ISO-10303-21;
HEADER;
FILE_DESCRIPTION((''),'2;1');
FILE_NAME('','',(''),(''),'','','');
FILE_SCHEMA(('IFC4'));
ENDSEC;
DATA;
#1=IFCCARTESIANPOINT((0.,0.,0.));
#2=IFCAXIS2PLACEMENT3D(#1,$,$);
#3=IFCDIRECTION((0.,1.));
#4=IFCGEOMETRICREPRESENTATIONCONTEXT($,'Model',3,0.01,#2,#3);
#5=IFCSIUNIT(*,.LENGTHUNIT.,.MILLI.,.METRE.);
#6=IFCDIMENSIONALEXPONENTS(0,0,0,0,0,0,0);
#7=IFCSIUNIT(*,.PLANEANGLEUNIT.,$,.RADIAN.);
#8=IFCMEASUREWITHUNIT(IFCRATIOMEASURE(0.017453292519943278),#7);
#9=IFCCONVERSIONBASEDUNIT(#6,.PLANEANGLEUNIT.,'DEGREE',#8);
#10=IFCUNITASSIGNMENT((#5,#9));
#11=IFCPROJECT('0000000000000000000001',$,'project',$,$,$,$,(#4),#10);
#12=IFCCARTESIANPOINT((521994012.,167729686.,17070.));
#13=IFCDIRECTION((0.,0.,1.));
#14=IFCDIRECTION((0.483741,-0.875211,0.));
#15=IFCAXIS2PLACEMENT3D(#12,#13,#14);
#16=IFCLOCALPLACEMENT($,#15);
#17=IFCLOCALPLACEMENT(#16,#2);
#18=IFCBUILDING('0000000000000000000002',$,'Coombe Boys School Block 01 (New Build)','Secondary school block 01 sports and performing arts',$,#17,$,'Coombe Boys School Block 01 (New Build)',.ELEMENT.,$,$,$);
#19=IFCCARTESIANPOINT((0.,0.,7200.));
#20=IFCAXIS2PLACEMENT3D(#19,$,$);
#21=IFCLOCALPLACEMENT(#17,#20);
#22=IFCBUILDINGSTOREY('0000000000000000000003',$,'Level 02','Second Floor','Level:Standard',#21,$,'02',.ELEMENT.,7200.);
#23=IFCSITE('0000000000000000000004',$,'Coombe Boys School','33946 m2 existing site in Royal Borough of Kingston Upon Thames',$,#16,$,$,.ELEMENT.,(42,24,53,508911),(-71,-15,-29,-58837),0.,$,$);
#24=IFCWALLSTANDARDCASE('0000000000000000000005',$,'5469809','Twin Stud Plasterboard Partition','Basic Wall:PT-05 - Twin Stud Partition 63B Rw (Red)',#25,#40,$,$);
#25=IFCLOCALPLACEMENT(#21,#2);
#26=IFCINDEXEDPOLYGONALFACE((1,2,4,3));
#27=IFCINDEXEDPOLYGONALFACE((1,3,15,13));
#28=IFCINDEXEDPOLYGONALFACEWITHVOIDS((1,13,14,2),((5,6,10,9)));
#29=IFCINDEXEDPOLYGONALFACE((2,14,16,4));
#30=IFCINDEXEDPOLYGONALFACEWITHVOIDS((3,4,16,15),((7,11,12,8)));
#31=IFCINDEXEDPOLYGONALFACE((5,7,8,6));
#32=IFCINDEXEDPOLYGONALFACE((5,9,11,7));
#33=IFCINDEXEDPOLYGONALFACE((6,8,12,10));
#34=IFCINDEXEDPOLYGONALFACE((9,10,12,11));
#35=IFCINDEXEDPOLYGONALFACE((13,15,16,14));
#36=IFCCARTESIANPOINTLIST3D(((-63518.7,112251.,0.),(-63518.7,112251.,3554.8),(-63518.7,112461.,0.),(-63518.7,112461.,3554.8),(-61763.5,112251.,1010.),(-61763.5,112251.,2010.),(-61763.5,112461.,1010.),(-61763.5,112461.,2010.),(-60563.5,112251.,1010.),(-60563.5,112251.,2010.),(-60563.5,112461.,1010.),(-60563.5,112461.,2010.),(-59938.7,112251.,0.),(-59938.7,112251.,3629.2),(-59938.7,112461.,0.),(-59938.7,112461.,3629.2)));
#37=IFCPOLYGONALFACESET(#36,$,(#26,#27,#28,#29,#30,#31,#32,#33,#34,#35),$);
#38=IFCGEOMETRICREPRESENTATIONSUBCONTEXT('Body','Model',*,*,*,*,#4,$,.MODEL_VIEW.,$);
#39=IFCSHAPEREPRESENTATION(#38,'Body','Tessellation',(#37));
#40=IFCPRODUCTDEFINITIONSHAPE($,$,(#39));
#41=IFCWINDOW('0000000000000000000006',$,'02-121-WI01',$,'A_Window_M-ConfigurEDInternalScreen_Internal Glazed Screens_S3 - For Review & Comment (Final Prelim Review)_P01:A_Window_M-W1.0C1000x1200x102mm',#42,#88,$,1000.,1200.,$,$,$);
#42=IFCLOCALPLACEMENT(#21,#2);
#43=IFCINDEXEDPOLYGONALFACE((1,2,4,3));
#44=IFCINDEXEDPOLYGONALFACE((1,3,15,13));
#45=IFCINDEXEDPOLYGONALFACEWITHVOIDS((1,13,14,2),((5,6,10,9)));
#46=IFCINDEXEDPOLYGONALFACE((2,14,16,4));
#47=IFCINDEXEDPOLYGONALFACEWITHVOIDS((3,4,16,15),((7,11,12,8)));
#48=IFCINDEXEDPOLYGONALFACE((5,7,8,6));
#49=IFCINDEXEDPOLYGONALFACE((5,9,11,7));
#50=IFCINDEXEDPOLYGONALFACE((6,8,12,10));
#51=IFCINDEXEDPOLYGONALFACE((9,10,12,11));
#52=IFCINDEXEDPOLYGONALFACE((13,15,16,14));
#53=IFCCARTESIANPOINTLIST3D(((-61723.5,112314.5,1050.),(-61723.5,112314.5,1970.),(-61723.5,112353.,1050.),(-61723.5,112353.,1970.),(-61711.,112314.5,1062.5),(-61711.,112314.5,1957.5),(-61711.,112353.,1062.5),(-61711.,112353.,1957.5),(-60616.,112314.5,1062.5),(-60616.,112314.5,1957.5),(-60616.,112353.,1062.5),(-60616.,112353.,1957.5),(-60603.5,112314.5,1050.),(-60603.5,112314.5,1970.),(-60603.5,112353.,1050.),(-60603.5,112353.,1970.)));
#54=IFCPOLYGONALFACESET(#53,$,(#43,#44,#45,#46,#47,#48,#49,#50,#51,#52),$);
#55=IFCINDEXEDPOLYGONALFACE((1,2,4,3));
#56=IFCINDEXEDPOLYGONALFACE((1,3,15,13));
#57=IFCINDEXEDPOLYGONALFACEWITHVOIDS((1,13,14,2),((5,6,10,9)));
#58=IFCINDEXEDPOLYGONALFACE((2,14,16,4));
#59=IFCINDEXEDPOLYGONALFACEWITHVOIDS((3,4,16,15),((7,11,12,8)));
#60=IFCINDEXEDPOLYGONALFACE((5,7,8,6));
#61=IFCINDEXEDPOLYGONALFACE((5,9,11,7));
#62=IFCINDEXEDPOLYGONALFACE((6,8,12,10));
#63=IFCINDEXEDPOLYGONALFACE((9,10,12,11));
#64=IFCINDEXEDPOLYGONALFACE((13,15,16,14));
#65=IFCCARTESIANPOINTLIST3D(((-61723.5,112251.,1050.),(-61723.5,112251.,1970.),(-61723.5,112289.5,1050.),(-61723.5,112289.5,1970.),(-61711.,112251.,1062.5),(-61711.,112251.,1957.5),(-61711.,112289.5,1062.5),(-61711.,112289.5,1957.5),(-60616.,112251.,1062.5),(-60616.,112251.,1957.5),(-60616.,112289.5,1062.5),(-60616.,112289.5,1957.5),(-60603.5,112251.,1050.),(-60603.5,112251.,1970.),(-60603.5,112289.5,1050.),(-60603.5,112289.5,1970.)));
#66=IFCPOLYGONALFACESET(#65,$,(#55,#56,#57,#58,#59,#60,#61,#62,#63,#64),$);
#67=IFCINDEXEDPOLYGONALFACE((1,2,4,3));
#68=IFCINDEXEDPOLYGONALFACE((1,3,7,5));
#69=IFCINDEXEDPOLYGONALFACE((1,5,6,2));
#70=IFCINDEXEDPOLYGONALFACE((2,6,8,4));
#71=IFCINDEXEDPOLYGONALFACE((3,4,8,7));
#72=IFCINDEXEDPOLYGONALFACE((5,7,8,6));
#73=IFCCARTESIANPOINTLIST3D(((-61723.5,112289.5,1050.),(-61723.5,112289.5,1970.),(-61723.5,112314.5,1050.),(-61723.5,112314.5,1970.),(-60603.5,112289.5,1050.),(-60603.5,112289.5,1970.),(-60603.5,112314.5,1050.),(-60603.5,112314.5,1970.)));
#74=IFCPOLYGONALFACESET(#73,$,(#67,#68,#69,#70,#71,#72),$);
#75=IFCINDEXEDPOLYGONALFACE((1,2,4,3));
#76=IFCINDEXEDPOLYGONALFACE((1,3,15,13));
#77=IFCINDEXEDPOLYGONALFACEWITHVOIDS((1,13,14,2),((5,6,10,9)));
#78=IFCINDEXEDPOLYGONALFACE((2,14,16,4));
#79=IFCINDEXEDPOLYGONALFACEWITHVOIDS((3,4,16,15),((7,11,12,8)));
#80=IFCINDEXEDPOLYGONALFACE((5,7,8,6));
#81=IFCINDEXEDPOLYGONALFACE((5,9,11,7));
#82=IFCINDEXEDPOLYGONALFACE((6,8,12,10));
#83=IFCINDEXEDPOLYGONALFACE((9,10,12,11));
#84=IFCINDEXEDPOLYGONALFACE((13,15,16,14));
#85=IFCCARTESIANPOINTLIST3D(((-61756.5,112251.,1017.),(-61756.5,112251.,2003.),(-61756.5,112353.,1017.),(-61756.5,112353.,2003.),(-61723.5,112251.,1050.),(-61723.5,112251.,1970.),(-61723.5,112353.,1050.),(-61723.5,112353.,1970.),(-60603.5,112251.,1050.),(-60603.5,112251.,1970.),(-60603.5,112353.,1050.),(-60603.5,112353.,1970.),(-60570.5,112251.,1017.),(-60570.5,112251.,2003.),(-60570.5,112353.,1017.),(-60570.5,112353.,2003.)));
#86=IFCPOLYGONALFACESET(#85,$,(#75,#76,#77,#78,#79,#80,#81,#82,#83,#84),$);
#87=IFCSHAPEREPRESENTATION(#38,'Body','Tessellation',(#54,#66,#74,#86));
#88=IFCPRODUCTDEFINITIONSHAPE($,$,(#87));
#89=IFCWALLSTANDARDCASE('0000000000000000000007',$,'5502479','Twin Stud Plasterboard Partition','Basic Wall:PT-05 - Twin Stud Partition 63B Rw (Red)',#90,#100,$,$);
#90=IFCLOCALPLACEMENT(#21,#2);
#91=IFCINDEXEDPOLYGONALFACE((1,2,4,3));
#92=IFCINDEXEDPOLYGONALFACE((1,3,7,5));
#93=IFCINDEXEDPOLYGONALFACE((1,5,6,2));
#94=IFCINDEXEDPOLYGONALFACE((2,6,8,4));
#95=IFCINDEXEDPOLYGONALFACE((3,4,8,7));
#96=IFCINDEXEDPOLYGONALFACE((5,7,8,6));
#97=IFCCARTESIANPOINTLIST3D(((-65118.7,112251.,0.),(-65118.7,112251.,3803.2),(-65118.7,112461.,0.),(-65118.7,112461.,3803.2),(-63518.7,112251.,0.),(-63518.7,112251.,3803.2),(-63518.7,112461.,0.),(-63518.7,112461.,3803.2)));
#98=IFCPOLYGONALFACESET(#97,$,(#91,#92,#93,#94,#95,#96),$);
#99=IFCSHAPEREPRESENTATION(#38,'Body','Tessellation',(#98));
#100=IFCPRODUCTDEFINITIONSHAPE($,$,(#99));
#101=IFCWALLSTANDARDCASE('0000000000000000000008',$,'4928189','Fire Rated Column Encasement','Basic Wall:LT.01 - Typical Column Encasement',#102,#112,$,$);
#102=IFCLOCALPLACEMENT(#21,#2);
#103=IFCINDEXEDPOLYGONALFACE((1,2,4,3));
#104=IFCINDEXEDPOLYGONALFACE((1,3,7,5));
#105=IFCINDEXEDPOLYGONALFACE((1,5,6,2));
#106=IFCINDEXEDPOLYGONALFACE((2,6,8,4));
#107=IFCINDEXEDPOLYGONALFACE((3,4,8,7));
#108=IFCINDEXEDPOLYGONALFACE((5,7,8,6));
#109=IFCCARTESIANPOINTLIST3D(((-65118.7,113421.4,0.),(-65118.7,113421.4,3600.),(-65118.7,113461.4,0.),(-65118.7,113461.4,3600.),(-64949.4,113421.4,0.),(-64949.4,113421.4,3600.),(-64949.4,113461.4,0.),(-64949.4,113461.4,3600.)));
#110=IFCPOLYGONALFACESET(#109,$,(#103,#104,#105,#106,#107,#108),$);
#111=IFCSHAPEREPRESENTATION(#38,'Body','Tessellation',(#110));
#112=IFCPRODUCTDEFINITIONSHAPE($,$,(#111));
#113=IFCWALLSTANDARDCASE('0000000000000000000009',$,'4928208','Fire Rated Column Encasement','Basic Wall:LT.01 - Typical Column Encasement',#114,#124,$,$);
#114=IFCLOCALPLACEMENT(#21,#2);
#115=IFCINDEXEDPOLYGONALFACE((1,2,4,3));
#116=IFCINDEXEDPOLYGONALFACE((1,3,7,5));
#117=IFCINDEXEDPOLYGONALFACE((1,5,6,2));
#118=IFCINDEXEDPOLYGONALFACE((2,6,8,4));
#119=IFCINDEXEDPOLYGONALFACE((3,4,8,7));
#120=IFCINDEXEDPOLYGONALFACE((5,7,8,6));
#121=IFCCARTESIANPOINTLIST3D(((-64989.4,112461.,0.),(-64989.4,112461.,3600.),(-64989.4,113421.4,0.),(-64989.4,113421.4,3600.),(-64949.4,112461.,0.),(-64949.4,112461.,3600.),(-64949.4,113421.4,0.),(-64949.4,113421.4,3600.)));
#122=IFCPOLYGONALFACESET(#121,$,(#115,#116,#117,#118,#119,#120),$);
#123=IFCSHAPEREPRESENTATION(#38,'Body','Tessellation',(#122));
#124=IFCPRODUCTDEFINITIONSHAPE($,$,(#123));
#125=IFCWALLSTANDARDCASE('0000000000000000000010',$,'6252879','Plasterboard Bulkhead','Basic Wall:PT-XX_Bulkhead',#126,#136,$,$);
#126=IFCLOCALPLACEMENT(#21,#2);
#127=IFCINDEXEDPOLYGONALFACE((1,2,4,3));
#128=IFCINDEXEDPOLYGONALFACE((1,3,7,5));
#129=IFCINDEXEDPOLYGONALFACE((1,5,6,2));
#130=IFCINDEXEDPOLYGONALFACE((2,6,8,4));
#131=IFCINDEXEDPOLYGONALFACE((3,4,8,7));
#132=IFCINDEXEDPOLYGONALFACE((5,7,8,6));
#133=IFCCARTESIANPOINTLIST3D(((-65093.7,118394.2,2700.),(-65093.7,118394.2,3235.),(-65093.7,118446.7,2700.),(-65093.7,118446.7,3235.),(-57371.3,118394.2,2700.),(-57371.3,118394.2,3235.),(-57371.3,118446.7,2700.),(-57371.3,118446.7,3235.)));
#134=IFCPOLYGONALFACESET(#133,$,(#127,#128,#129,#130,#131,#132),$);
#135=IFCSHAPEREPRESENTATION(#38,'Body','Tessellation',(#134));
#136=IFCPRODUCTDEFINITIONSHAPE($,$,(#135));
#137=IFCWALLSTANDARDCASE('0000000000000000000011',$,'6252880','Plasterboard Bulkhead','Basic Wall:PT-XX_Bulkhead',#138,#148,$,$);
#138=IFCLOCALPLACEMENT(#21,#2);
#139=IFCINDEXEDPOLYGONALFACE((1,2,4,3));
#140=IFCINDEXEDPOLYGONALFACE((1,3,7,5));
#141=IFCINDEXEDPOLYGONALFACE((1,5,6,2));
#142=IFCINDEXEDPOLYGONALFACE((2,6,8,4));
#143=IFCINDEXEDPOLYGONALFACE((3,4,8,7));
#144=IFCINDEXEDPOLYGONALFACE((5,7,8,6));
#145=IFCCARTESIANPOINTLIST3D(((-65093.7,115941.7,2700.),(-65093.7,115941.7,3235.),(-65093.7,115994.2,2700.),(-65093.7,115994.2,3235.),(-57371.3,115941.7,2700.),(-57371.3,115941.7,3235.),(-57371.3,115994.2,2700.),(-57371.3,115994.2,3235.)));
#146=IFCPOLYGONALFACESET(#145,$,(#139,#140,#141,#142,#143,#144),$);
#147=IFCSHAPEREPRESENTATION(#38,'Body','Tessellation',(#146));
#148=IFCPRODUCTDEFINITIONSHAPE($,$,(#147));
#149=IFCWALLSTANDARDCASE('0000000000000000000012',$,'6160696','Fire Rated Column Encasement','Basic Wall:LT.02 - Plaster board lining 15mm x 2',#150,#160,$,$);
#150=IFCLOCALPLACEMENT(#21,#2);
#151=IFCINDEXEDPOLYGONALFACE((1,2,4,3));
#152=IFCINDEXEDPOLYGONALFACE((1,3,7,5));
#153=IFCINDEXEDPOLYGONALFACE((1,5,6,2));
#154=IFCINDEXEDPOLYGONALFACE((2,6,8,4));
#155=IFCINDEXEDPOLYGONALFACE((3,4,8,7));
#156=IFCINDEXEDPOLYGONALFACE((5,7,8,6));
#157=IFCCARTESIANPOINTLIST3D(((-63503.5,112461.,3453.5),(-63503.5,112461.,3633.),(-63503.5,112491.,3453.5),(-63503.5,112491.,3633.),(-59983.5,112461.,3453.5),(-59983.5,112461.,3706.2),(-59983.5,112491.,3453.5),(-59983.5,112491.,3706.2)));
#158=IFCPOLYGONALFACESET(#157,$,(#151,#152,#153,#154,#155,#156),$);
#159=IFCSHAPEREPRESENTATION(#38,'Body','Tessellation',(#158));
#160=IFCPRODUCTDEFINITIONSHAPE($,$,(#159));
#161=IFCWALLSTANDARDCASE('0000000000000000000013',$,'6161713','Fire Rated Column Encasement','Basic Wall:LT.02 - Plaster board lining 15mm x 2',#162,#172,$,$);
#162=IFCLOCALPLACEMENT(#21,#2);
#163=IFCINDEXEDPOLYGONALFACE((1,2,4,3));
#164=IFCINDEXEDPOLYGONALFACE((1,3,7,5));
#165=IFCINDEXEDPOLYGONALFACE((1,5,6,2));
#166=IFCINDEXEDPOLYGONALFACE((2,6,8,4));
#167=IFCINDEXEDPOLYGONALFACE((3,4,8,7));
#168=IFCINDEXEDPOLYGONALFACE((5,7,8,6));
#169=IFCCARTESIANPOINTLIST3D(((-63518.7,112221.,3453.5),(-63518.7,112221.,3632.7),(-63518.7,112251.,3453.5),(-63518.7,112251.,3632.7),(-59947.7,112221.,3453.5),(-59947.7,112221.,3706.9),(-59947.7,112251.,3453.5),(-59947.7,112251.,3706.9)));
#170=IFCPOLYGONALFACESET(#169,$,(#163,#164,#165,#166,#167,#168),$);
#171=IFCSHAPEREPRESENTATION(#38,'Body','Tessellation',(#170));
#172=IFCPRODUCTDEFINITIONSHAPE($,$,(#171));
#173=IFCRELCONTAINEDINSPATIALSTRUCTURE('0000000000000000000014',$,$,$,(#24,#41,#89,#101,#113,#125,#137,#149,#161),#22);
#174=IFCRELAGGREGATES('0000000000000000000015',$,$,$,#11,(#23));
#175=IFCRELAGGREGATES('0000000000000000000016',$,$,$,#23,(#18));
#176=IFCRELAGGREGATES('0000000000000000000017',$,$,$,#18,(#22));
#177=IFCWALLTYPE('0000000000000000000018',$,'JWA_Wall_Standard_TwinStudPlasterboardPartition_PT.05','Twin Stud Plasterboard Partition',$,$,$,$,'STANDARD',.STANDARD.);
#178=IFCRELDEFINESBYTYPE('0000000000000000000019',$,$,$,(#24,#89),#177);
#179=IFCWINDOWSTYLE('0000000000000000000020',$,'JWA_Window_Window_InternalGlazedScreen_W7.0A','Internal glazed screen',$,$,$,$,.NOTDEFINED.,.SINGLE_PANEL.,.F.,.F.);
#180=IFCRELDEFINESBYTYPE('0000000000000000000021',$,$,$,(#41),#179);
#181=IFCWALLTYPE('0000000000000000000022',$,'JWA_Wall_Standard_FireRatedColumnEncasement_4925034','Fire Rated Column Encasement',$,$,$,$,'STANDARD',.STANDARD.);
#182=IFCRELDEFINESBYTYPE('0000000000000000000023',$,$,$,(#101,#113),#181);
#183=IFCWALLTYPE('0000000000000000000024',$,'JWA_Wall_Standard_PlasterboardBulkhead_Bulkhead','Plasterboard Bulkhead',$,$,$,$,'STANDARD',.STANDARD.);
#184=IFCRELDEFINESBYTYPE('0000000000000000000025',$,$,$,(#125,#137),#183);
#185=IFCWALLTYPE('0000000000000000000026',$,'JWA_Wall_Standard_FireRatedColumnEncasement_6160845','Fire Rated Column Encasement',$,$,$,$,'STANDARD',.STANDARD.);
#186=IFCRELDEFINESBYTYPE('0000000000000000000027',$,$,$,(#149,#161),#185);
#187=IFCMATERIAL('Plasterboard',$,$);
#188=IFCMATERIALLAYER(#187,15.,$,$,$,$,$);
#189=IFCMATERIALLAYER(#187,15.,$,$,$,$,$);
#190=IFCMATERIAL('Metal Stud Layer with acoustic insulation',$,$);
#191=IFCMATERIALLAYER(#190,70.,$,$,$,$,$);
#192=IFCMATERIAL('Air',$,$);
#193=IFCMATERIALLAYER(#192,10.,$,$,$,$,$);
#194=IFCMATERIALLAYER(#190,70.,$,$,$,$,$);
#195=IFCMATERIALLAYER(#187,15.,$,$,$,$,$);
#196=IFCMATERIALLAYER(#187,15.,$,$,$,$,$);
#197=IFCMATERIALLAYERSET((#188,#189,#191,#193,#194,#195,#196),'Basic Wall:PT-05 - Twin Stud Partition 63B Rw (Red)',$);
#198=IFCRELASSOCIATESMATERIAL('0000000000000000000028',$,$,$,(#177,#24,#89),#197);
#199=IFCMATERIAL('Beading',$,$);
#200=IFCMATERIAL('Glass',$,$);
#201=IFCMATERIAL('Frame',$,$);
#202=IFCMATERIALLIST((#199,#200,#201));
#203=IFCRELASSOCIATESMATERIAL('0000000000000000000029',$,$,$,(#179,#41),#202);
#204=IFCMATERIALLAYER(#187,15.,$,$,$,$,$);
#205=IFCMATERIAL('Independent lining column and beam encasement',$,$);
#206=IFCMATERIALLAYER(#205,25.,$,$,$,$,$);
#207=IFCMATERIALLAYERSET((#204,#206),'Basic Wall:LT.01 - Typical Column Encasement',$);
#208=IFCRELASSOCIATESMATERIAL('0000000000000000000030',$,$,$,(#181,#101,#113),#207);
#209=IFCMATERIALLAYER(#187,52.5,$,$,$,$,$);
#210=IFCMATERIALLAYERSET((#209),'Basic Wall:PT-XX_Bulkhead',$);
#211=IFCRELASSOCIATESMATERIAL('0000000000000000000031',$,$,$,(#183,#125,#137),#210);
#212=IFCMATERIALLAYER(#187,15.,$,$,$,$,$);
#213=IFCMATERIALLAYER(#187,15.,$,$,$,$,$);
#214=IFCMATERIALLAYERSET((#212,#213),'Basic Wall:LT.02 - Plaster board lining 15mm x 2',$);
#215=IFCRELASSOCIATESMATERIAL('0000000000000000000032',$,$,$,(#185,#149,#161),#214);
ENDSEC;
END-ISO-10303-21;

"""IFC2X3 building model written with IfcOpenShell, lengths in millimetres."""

from ifc_helpers import new_model, entity, si_unit, converted_unit, direction, frame, frame_2d, origin, origin_2d_with_axis, place, context, subcontext, project, spatial, polyline, rectangle, outline, extrude, clip, halfspace, source, transform, mapped, material, material_list, layer, layer_set, layer_usage, type_object, type_shapes, element, fill, save


model = new_model("IFC2X3")

# Units and contexts
model_context = context("Model", 3, precision=0.01, world=origin(), true_north=direction((0.0, 1.0)))
body_context = subcontext(model_context, "Body", "Model", "MODEL_VIEW")
ifc_project = project(units=[si_unit("LENGTHUNIT", "METRE", prefix="MILLI"), converted_unit("PLANEANGLEUNIT", "DEGREE", entity("IfcRatioMeasure", 0.017453292519943278), si_unit("PLANEANGLEUNIT", "RADIAN"), dimensions=[0, 0, 0, 0, 0, 0, 0])], contexts=[model_context])

# Site, building, storey
site_placement = place(None, frame((521994012.0, 167729686.0, 17070.0), z_axis=(0.0, 0.0, 1.0), x_axis=(0.483741, -0.875211, 0.0)))
site = spatial("IfcSite", under=ifc_project, at=site_placement, Name="Coombe Boys School", Description="33946 m2 existing site in Royal Borough of Kingston Upon Thames", CompositionType="ELEMENT", RefLatitude=(42, 24, 53, 508911), RefLongitude=(-71, -15, -29, -58837), RefElevation=0.0)
building_placement = place(site_placement, origin())
building = spatial("IfcBuilding", under=site, at=building_placement, Name="Coombe Boys School Block 01 (New Build)", Description="Secondary school block 01 sports and performing arts", LongName="Coombe Boys School Block 01 (New Build)", CompositionType="ELEMENT")
storey_placement = place(building_placement, frame((0.0, 0.0, 7200.0)))
storey = spatial("IfcBuildingStorey", under=building, at=storey_placement, Name="Level 02", Description="Second Floor", ObjectType="Level:Standard", LongName="02", CompositionType="ELEMENT", Elevation=7200.0)

# Shared definitions
ifc_material_1 = material(Name="Plasterboard")

# Shared definitions
ifc_material_2 = material(Name="Air")

# Wall, opening, window
ifc_layer_1 = layer(ifc_material_1, 15.0)
ifc_layer_2 = layer(ifc_material_1, 15.0)
ifc_material_3 = material(Name="Metal Stud Layer with acoustic insulation")
ifc_layer_3 = layer(ifc_material_3, 70.0)
ifc_layer_4 = layer(ifc_material_2, 10.0)
ifc_layer_5 = layer(ifc_material_3, 70.0)
ifc_layer_6 = layer(ifc_material_1, 15.0)
ifc_layer_7 = layer(ifc_material_1, 15.0)
ifc_layer_set_1 = layer_set([ifc_layer_1, ifc_layer_2, ifc_layer_3, ifc_layer_4, ifc_layer_5, ifc_layer_6, ifc_layer_7], Name="Basic Wall:PT-05 - Twin Stud Partition 63B Rw (Red)")
ifc_layer_usage_1 = layer_usage(ifc_layer_set_1, "AXIS2", "NEGATIVE", 105.0)
wall_type_1 = type_object("IfcWallType", Name="JWA_Wall_Standard_TwinStudPlasterboardPartition_PT.05", Description="Twin Stud Plasterboard Partition", ElementType="STANDARD", PredefinedType="STANDARD", material=ifc_layer_set_1)
wall_1_placement = place(storey_placement, frame((-59938.7, 112356.0, 0.0), z_axis=(0.0, 0.0, 1.0), x_axis=(-1.0, 0.0, 0.0)))
wall_1 = element("IfcWallStandardCase", 1, at=wall_1_placement, inside=storey, type_object=wall_type_1, material=ifc_layer_usage_1, Name="5469809", Description="Twin Stud Plasterboard Partition", ObjectType="Basic Wall:PT-05 - Twin Stud Partition 63B Rw (Red)", context=body_context, shape_type="Clipping", body=[
    clip(extrude(rectangle(XDim=3580.0, YDim=210.0, at=frame_2d((1790.0, 0.0), x_axis=(-1.0, 0.0))), origin(), (0.0, 0.0, 1.0), 3629.2), halfspace(frame((0.0, -105.0, 3629.2), z_axis=(0.020777, 0.0, 0.999784), x_axis=(0.0, 1.0, 0.0)), False)),
])
opening_1_placement = place(wall_1_placement, frame((-59938.7, 112356.0, 0.0), z_axis=(0.0, 0.0, 1.0), x_axis=(-1.0, 0.0, 0.0)))
opening_1 = element("IfcOpeningElement", 2, at=opening_1_placement, cuts=wall_1, ObjectType="Opening", context=body_context, shape_type="SweptSolid", body=[
    extrude(rectangle(XDim=1000.0, YDim=1200.0, at=frame_2d((0.0, 0.0), x_axis=(0.0, 1.0))), frame((-61163.5, 112461.0, 1510.0), z_axis=(0.0, -1.0, 0.0), x_axis=(-1.0, 0.0, 0.0)), (0.0, 0.0, 1.0), 210.0),
])
ifc_material_4 = material(Name="Beading")
ifc_material_5 = material(Name="Glass")
ifc_material_6 = material(Name="Frame")
ifc_material_list = material_list([ifc_material_4, ifc_material_5, ifc_material_6])
window_style = type_object("IfcWindowStyle", Name="JWA_Window_Window_InternalGlazedScreen_W7.0A", Description="Internal glazed screen", ConstructionType="NOTDEFINED", OperationType="SINGLE_PANEL", ParameterTakesPrecedence=False, Sizeable=False, material=ifc_material_list)
shared_shape_1 = source(origin(), body_context, "Body", "SweptSolid", [
    extrude(outline(polyline([(-560.0, -460.0), (560.0, -460.0), (560.0, 460.0), (-560.0, 460.0), (-560.0, -460.0)]), holes=[polyline([(-547.5, -447.5), (-547.5, 447.5), (547.5, 447.5), (547.5, -447.5), (-547.5, -447.5)])]), frame((600.0, -102.0, 500.0), z_axis=(0.0, 1.0, 0.0), x_axis=(1.0, 0.0, 0.0)), (0.0, 0.0, 1.0), 38.5),
    extrude(outline(polyline([(-560.0, -460.0), (560.0, -460.0), (560.0, 460.0), (-560.0, 460.0), (-560.0, -460.0)]), holes=[polyline([(-547.5, -447.5), (-547.5, 447.5), (547.5, 447.5), (547.5, -447.5), (-547.5, -447.5)])]), frame((600.0, -38.5, 500.0), z_axis=(0.0, 1.0, 0.0), x_axis=(1.0, 0.0, 0.0)), (0.0, 0.0, 1.0), 38.5),
    extrude(rectangle(XDim=25.0, YDim=1120.0, at=origin_2d_with_axis()), frame((600.0, -51.0, 40.0), z_axis=(0.0, 0.0, 1.0), x_axis=(0.0, 1.0, 0.0)), (0.0, 0.0, 1.0), 920.0),
    extrude(outline(polyline([(-493.0, -593.0), (493.0, -593.0), (493.0, 593.0), (-493.0, 593.0), (-493.0, -593.0)]), holes=[polyline([(-460.0, -560.0), (-460.0, 560.0), (460.0, 560.0), (460.0, -560.0), (-460.0, -560.0)])]), frame((600.0, -102.0, 500.0), z_axis=(0.0, 1.0, 0.0), x_axis=(0.0, 0.0, -1.0)), (0.0, 0.0, 1.0), 102.0),
])
type_shapes(window_style, [shared_shape_1])
window_placement = place(opening_1_placement, frame((-60563.5, 112251.0, 1010.0), z_axis=(0.0, 0.0, 1.0), x_axis=(-1.0, 0.0, 0.0)))
window = element("IfcWindow", 3, at=window_placement, inside=storey, type_object=window_style, material=ifc_material_list, Name="02-121-WI01", ObjectType="A_Window_M-ConfigurEDInternalScreen_Internal Glazed Screens_S3 - For Review & Comment (Final Prelim Review)_P01:A_Window_M-W1.0C1000x1200x102mm", OverallHeight=1000.0, OverallWidth=1200.0, context=body_context, shape_type="MappedRepresentation", body=[
    mapped(shared_shape_1, transform((0.0, 0.0, 0.0), scale=1.0)),
])
fill(opening_1, window)

# Walls
wall_2_placement = place(storey_placement, frame((-63518.7, 112356.0, 0.0), z_axis=(0.0, 0.0, 1.0), x_axis=(-1.0, 0.0, 0.0)))
element("IfcWallStandardCase", 4, at=wall_2_placement, inside=storey, type_object=wall_type_1, material=ifc_layer_usage_1, Name="5502479", Description="Twin Stud Plasterboard Partition", ObjectType="Basic Wall:PT-05 - Twin Stud Partition 63B Rw (Red)", context=body_context, shape_type="SweptSolid", body=[
    extrude(rectangle(XDim=1600.0, YDim=210.0, at=frame_2d((800.0, 0.0), x_axis=(-1.0, 0.0))), origin(), (0.0, 0.0, 1.0), 3803.2),
])
ifc_layer_8 = layer(ifc_material_1, 15.0)
ifc_material_7 = material(Name="Independent lining column and beam encasement")
ifc_layer_9 = layer(ifc_material_7, 25.0)
ifc_layer_set_2 = layer_set([ifc_layer_8, ifc_layer_9], Name="Basic Wall:LT.01 - Typical Column Encasement")
ifc_layer_usage_2 = layer_usage(ifc_layer_set_2, "AXIS2", "NEGATIVE", 20.0)
wall_type_2 = type_object("IfcWallType", Name="JWA_Wall_Standard_FireRatedColumnEncasement_4925034", Description="Fire Rated Column Encasement", ElementType="STANDARD", PredefinedType="STANDARD", material=ifc_layer_set_2)
wall_3_placement = place(storey_placement, frame((-65118.7, 113441.4, 0.0)))
element("IfcWallStandardCase", 5, at=wall_3_placement, inside=storey, type_object=wall_type_2, material=ifc_layer_usage_2, Name="4928189", Description="Fire Rated Column Encasement", ObjectType="Basic Wall:LT.01 - Typical Column Encasement", context=body_context, shape_type="SweptSolid", body=[
    extrude(rectangle(XDim=169.3, YDim=40.0, at=frame_2d((84.7, 0.0), x_axis=(-1.0, 0.0))), origin(), (0.0, 0.0, 1.0), 3600.0),
])
wall_4_placement = place(storey_placement, frame((-64969.4, 113421.4, 0.0), z_axis=(0.0, 0.0, 1.0), x_axis=(0.0, -1.0, 0.0)))
element("IfcWallStandardCase", 6, at=wall_4_placement, inside=storey, type_object=wall_type_2, material=ifc_layer_usage_2, Name="4928208", Description="Fire Rated Column Encasement", ObjectType="Basic Wall:LT.01 - Typical Column Encasement", context=body_context, shape_type="SweptSolid", body=[
    extrude(rectangle(XDim=960.4, YDim=40.0, at=frame_2d((480.2, 0.0), x_axis=(-1.0, 0.0))), origin(), (0.0, 0.0, 1.0), 3600.0),
])

# Walls
ifc_layer_10 = layer(ifc_material_1, 52.5)
ifc_layer_set_3 = layer_set([ifc_layer_10], Name="Basic Wall:PT-XX_Bulkhead")
ifc_layer_usage_3 = layer_usage(ifc_layer_set_3, "AXIS2", "NEGATIVE", 26.2)
wall_type_3 = type_object("IfcWallType", Name="JWA_Wall_Standard_PlasterboardBulkhead_Bulkhead", Description="Plasterboard Bulkhead", ElementType="STANDARD", PredefinedType="STANDARD", material=ifc_layer_set_3)
wall_5_placement = place(storey_placement, frame((-65093.7, 118420.5, 2700.0)))
element("IfcWallStandardCase", 7, at=wall_5_placement, inside=storey, type_object=wall_type_3, material=ifc_layer_usage_3, Name="6252879", Description="Plasterboard Bulkhead", ObjectType="Basic Wall:PT-XX_Bulkhead", context=body_context, shape_type="SweptSolid", body=[
    extrude(rectangle(XDim=7722.4, YDim=52.5, at=frame_2d((3861.2, 0.0), x_axis=(-1.0, 0.0))), origin(), (0.0, 0.0, 1.0), 535.0),
])
wall_6_placement = place(storey_placement, frame((-65093.7, 115968.0, 2700.0)))
element("IfcWallStandardCase", 8, at=wall_6_placement, inside=storey, type_object=wall_type_3, material=ifc_layer_usage_3, Name="6252880", Description="Plasterboard Bulkhead", ObjectType="Basic Wall:PT-XX_Bulkhead", context=body_context, shape_type="SweptSolid", body=[
    extrude(rectangle(XDim=7722.4, YDim=52.5, at=frame_2d((3861.2, 0.0), x_axis=(-1.0, 0.0))), origin(), (0.0, 0.0, 1.0), 535.0),
])
ifc_layer_11 = layer(ifc_material_1, 15.0)
ifc_layer_12 = layer(ifc_material_1, 15.0)
ifc_layer_set_4 = layer_set([ifc_layer_11, ifc_layer_12], Name="Basic Wall:LT.02 - Plaster board lining 15mm x 2")
ifc_layer_usage_4 = layer_usage(ifc_layer_set_4, "AXIS2", "NEGATIVE", 15.0)
wall_type_4 = type_object("IfcWallType", Name="JWA_Wall_Standard_FireRatedColumnEncasement_6160845", Description="Fire Rated Column Encasement", ElementType="STANDARD", PredefinedType="STANDARD", material=ifc_layer_set_4)
wall_7_placement = place(storey_placement, frame((-63503.5, 112476.0, 3453.5)))
element("IfcWallStandardCase", 9, at=wall_7_placement, inside=storey, type_object=wall_type_4, material=ifc_layer_usage_4, Name="6160696", Description="Fire Rated Column Encasement", ObjectType="Basic Wall:LT.02 - Plaster board lining 15mm x 2", context=body_context, shape_type="Clipping", body=[
    clip(extrude(rectangle(XDim=3520.0, YDim=30.0, at=frame_2d((1760.0, 0.0), x_axis=(-1.0, 0.0))), origin(), (0.0, 0.0, 1.0), 252.7), halfspace(frame((0.0, -15.0, 179.6), z_axis=(-0.020768, 0.0, 0.999784), x_axis=(0.0, 1.0, 0.0)), False)),
])
wall_8_placement = place(storey_placement, frame((-63518.7, 112236.0, 3453.5)))
element("IfcWallStandardCase", 10, at=wall_8_placement, inside=storey, type_object=wall_type_4, material=ifc_layer_usage_4, Name="6161713", Description="Fire Rated Column Encasement", ObjectType="Basic Wall:LT.02 - Plaster board lining 15mm x 2", context=body_context, shape_type="Clipping", body=[
    clip(extrude(rectangle(XDim=3571.0, YDim=30.0, at=frame_2d((1785.5, 0.0), x_axis=(-1.0, 0.0))), origin(), (0.0, 0.0, 1.0), 253.4), halfspace(frame((0.0, -15.0, 179.2), z_axis=(-0.020768, 0.0, 0.999784), x_axis=(0.0, 1.0, 0.0)), False)),
])

save(model, "model.ifc")
